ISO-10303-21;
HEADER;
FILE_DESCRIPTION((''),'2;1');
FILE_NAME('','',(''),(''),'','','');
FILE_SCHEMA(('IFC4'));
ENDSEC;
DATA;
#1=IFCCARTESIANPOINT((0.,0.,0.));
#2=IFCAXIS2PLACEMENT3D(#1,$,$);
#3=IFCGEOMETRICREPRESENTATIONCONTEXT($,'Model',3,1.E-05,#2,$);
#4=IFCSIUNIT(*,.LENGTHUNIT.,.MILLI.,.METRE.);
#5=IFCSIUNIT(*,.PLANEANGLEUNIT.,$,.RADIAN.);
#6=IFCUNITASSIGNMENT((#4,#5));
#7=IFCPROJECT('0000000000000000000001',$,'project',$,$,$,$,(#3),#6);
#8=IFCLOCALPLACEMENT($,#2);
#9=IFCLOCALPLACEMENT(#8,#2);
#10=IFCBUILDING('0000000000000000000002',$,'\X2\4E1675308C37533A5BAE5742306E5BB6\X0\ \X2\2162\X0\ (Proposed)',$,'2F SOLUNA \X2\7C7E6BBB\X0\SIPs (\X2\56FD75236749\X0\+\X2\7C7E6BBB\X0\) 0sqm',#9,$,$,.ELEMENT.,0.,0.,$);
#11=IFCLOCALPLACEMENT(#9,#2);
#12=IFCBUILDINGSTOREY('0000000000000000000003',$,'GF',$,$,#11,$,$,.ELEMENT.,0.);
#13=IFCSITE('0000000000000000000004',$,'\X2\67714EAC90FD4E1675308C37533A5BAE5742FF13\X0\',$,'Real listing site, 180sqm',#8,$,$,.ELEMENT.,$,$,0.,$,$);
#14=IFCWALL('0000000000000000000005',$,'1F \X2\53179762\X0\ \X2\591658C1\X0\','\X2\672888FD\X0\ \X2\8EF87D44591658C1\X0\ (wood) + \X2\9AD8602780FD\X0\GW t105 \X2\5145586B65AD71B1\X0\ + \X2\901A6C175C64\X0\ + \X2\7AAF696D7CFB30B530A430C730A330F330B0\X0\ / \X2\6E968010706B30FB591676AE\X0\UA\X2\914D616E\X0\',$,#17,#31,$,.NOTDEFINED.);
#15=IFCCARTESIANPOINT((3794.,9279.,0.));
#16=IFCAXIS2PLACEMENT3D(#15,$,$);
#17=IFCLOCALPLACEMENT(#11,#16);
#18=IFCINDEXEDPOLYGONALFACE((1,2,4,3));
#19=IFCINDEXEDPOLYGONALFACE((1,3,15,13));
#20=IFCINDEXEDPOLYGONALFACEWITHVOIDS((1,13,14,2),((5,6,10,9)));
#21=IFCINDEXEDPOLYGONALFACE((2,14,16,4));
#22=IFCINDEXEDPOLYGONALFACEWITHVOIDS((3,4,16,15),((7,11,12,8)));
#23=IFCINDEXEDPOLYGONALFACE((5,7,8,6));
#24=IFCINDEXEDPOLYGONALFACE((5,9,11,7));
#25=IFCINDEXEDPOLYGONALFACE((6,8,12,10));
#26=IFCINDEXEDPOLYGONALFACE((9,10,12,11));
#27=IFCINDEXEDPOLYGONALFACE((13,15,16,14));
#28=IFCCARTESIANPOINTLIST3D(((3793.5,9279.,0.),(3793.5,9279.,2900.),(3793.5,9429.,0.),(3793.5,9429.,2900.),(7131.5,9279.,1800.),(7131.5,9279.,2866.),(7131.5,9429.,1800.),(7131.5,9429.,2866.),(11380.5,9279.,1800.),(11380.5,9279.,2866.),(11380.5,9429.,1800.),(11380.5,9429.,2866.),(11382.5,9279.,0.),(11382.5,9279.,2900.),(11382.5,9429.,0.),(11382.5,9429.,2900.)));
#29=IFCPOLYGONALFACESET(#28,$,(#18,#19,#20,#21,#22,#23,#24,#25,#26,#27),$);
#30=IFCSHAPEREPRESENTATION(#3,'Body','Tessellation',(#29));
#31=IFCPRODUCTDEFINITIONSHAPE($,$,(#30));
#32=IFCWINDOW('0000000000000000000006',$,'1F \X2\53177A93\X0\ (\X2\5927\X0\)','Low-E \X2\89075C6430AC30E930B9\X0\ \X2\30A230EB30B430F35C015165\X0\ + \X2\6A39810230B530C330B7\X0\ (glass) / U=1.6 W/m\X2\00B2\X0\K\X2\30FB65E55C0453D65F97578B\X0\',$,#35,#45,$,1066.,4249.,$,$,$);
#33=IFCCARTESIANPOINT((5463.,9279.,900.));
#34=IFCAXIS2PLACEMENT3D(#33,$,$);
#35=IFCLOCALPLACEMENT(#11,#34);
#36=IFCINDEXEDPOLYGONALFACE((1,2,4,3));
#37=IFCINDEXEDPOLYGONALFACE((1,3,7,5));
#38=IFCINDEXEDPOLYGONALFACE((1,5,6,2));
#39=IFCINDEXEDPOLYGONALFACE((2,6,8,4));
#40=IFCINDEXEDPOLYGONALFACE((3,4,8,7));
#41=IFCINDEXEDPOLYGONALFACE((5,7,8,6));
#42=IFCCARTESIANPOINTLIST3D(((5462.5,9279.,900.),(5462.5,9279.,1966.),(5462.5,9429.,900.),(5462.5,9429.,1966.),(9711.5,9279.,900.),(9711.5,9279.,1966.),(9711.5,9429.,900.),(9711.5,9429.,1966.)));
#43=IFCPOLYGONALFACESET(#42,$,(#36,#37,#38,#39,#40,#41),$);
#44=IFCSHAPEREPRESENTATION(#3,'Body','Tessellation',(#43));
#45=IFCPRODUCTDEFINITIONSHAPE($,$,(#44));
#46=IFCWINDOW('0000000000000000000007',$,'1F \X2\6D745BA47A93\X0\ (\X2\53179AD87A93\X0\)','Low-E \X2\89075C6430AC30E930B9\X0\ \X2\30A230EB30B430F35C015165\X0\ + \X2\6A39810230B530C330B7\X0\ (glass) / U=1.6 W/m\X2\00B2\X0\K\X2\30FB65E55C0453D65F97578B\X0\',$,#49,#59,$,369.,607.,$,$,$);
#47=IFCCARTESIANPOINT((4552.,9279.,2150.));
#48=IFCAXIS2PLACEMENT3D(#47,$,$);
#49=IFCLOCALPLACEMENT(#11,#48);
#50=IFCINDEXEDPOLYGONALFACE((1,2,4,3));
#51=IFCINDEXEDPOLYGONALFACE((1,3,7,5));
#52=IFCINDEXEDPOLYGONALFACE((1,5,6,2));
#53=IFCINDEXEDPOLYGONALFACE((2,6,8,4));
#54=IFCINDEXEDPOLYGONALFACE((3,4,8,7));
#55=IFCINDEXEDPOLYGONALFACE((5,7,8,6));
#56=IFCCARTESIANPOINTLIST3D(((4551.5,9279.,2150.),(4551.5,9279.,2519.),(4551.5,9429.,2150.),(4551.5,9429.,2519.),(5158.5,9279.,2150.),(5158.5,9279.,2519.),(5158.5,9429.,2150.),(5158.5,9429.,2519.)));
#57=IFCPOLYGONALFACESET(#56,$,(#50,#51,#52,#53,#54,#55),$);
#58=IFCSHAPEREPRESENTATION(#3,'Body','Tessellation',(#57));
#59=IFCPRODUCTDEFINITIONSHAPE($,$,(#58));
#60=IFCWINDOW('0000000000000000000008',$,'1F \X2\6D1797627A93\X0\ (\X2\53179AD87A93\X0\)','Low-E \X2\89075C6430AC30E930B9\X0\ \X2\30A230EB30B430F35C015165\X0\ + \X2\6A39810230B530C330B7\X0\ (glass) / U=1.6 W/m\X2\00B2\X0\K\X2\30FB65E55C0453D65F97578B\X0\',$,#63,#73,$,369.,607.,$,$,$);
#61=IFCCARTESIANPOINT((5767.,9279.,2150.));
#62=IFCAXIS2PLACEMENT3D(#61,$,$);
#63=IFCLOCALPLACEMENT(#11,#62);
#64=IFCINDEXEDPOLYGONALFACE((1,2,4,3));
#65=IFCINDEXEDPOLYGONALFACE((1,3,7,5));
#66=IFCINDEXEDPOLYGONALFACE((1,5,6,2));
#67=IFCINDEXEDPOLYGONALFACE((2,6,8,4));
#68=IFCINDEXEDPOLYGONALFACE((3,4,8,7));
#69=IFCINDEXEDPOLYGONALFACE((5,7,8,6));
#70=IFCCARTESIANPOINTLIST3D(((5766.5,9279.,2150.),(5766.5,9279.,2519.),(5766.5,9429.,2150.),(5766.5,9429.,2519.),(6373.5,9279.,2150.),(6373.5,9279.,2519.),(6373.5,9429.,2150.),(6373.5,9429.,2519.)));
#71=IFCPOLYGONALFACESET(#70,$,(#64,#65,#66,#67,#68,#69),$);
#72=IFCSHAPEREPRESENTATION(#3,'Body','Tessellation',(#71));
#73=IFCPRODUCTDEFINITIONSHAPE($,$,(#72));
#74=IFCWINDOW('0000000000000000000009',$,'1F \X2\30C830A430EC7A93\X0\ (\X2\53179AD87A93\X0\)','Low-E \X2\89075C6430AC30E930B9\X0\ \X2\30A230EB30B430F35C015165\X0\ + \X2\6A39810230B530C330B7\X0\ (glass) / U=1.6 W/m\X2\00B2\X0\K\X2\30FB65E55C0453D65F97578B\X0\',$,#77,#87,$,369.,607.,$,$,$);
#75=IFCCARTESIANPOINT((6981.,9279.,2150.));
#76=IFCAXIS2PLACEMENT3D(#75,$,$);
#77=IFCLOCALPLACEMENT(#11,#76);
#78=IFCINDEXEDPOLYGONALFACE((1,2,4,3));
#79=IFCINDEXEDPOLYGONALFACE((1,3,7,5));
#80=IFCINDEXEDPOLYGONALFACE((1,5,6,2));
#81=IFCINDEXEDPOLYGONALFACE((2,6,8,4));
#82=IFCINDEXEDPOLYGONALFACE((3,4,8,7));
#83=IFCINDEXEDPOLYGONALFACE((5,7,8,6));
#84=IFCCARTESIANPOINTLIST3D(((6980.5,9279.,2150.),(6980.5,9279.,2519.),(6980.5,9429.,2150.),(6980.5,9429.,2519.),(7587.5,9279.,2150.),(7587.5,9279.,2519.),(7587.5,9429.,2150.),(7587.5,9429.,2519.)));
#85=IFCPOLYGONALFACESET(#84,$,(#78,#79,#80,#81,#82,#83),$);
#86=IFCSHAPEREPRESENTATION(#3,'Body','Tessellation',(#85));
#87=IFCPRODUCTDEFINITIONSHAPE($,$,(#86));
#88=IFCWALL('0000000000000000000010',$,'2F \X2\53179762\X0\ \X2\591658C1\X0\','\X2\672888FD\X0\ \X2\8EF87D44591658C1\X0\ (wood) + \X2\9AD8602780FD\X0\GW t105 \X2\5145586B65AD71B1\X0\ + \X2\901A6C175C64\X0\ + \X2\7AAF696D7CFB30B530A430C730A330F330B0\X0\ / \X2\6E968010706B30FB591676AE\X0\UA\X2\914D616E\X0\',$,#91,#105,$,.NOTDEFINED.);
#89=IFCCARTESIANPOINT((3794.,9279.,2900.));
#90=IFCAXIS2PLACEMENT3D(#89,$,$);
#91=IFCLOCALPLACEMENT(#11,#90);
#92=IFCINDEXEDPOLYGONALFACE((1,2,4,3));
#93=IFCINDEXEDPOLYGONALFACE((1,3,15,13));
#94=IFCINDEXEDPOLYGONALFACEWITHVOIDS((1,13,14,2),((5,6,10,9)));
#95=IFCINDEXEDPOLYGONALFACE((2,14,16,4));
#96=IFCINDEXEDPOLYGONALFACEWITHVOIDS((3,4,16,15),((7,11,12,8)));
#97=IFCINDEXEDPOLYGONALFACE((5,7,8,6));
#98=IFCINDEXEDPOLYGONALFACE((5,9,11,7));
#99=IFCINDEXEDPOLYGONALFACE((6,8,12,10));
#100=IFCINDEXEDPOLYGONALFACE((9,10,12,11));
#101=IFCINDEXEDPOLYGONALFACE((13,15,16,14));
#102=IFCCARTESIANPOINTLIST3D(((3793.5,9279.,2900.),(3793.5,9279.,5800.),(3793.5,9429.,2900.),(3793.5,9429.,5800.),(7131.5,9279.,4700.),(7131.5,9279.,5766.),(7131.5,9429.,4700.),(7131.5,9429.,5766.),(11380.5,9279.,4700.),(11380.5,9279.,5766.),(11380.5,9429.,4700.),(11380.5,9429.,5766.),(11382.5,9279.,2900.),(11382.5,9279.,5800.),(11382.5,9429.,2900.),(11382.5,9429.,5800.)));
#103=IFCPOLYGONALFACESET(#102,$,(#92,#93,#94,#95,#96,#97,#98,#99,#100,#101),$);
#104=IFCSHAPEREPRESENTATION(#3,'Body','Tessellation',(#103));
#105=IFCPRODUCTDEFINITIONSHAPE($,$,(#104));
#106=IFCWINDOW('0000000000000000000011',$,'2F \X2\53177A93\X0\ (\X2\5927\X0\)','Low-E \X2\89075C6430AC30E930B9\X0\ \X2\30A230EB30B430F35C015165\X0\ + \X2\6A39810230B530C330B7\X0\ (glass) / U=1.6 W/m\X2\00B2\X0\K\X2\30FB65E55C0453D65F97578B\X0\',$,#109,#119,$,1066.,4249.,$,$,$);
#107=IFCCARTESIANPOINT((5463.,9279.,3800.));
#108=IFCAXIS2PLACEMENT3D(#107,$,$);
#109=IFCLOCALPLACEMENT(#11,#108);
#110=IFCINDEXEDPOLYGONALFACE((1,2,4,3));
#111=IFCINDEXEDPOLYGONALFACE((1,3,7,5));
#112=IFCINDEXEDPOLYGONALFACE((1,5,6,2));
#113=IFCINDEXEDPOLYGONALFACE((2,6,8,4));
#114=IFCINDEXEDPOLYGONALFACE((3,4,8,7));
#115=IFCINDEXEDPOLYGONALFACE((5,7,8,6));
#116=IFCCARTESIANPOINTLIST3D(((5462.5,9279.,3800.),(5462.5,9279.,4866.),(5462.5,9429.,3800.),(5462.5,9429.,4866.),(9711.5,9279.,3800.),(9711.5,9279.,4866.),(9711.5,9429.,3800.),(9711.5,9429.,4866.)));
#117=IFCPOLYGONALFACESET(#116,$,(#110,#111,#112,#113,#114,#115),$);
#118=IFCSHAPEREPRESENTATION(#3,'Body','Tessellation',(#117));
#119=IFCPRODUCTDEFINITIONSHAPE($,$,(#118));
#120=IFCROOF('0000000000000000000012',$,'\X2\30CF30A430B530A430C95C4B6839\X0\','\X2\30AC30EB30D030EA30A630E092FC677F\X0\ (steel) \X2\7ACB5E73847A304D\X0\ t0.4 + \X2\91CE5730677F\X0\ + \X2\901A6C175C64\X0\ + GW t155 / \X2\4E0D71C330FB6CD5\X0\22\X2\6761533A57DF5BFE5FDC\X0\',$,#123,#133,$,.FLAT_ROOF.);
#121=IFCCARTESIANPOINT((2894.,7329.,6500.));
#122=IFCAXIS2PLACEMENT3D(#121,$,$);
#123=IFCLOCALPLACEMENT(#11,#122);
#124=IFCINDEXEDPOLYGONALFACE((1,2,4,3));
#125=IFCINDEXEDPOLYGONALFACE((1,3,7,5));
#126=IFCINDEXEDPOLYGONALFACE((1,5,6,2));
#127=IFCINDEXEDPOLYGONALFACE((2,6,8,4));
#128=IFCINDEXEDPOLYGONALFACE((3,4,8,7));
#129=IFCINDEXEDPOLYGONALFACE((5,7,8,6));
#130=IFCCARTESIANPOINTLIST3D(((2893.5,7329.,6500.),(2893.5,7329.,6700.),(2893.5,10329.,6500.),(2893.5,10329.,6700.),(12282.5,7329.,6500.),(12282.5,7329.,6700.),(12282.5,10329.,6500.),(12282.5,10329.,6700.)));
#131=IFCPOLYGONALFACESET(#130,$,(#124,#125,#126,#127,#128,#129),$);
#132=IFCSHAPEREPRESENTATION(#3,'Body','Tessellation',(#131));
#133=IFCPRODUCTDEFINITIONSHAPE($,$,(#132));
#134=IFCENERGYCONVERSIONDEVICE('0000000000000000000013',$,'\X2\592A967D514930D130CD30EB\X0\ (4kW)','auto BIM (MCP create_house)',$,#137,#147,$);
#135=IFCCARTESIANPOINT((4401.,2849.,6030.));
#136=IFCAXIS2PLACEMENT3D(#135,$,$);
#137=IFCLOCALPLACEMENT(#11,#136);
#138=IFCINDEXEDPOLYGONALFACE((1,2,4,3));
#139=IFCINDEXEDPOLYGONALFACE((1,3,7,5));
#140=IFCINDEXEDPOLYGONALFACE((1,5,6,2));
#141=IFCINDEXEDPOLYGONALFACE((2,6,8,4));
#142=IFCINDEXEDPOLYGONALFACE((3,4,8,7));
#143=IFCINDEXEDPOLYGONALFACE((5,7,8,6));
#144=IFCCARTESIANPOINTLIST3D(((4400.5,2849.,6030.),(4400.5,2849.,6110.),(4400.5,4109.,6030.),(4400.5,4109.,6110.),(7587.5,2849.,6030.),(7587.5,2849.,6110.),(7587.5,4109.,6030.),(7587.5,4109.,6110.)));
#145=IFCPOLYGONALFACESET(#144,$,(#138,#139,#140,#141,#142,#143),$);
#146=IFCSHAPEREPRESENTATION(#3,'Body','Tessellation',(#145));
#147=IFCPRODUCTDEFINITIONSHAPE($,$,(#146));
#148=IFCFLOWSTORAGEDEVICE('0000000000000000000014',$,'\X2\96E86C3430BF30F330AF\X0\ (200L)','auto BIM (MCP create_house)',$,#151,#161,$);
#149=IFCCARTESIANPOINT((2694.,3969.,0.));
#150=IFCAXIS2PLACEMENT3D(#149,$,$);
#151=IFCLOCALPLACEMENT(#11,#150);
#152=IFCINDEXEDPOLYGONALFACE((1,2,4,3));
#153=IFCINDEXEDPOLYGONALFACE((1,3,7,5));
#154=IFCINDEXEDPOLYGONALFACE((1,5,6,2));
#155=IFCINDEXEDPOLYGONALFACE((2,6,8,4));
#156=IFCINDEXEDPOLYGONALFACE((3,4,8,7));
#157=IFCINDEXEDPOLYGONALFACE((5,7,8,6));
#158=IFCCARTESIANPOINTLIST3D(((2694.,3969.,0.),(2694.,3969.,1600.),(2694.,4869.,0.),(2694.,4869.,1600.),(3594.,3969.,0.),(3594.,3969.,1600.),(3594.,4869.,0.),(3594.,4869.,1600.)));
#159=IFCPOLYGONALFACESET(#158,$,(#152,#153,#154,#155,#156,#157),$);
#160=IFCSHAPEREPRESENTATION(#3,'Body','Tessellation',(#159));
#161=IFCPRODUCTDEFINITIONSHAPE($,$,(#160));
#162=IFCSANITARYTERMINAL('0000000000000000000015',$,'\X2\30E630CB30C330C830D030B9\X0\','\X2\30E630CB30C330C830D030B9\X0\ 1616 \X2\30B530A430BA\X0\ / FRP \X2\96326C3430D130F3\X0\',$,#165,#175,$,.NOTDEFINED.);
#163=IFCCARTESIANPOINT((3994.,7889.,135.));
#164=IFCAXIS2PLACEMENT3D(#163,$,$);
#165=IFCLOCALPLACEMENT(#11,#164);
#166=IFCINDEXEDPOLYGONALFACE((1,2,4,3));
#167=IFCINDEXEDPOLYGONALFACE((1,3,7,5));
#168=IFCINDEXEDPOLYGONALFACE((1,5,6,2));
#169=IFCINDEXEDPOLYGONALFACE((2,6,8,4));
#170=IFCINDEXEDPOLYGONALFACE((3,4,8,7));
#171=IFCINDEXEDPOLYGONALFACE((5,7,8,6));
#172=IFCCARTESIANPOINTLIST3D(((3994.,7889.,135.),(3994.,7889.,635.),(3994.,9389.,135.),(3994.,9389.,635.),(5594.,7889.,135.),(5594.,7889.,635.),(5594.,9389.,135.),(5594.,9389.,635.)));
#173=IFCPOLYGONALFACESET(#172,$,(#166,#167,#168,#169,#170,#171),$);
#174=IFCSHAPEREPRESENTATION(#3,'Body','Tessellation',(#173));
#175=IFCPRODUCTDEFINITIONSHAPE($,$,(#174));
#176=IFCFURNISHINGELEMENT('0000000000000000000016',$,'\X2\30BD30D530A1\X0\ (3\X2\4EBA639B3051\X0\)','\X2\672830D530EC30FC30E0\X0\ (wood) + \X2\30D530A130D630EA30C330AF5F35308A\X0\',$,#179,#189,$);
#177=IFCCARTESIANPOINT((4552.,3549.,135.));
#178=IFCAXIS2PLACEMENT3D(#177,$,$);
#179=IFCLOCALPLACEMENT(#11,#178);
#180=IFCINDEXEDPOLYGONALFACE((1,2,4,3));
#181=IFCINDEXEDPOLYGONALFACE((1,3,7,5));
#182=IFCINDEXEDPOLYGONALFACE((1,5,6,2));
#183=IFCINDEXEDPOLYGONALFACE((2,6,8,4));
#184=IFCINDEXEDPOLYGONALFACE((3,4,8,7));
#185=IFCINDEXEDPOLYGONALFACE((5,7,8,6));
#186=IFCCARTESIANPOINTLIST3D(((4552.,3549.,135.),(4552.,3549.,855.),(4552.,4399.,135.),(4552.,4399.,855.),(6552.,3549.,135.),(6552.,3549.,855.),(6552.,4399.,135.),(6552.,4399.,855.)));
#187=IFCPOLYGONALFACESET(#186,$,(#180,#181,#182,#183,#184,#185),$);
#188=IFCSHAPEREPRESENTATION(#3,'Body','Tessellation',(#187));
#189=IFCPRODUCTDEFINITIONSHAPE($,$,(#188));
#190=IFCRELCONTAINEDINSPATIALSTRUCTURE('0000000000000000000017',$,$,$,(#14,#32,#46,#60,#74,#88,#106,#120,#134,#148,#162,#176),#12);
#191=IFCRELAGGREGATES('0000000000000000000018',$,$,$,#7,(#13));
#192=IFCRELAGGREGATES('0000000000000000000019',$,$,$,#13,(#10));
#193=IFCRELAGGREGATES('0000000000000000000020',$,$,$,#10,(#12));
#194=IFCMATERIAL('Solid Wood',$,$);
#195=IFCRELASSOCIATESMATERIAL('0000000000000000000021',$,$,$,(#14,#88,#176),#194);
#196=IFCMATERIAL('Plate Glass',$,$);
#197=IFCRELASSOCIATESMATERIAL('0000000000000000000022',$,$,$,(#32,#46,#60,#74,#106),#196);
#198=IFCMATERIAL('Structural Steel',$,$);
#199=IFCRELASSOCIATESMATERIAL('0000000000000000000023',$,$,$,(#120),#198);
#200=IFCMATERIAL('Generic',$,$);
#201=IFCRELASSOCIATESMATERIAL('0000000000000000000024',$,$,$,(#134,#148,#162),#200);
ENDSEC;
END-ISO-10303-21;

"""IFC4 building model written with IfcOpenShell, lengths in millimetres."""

from ifc_helpers import new_model, si_unit, frame, frame_2d, origin, place, context, project, spatial, rectangle, extrude, material, element, fill, save


model = new_model("IFC4")

# Units and contexts
model_context = context("Model", 3, precision=1e-05, world=origin())
ifc_project = project(units=[si_unit("LENGTHUNIT", "METRE", prefix="MILLI"), si_unit("PLANEANGLEUNIT", "RADIAN")], contexts=[model_context])

# Site, building, storey
site_placement = place(None, origin())
site = spatial("IfcSite", under=ifc_project, at=site_placement, Name="東京都世田谷区宮坂３", ObjectType="Real listing site, 180sqm", CompositionType="ELEMENT", RefElevation=0.0)
building_placement = place(site_placement, origin())
building = spatial("IfcBuilding", under=site, at=building_placement, Name="世田谷区宮坂の家 Ⅲ (Proposed)", ObjectType="2F SOLUNA 籾殻SIPs (国産杉+籾殻) 0sqm", CompositionType="ELEMENT", ElevationOfRefHeight=0.0, ElevationOfTerrain=0.0)
storey_placement = place(building_placement, origin())
storey = spatial("IfcBuildingStorey", under=building, at=storey_placement, Name="GF", CompositionType="ELEMENT", Elevation=0.0)

# Wall, openings, windows
ifc_material_1 = material(Name="Solid Wood")
wall_1_placement = place(storey_placement, frame((3794.0, 9279.0, 0.0)))
wall_1 = element("IfcWall", 1, at=wall_1_placement, inside=storey, material=ifc_material_1, Name="1F 北面 外壁", Description="木製 軸組外壁 (wood) + 高性能GW t105 充填断熱 + 通気層 + 窯業系サイディング / 準耐火・外皮UA配慮", PredefinedType="NOTDEFINED", context=model_context, shape_type="SweptSolid", body=[
    extrude(rectangle(XDim=7589.0, YDim=150.0, at=frame_2d((3794.0, 75.0))), frame((3794.0, 9279.0, 0.0)), (0.0, 0.0, 1.0), 2900.0),
])
opening_1_placement = place(storey_placement, frame((5463.0, 9279.0, 900.0)))
opening_1 = element("IfcOpeningElement", 2, at=opening_1_placement, cuts=wall_1, PredefinedType="NOTDEFINED", context=model_context, shape_type="SweptSolid", body=[
    extrude(rectangle(XDim=4249.0, YDim=150.0, at=frame_2d((2124.0, 75.0))), frame((5463.0, 9279.0, 900.0)), (0.0, 0.0, 1.0), 1066.0),
])
opening_2_placement = place(storey_placement, frame((4552.0, 9279.0, 2150.0)))
opening_2 = element("IfcOpeningElement", 3, at=opening_2_placement, cuts=wall_1, PredefinedType="NOTDEFINED", context=model_context, shape_type="SweptSolid", body=[
    extrude(rectangle(XDim=607.0, YDim=150.0, at=frame_2d((303.0, 75.0))), frame((4552.0, 9279.0, 2150.0)), (0.0, 0.0, 1.0), 369.0),
])
opening_3_placement = place(storey_placement, frame((5767.0, 9279.0, 2150.0)))
opening_3 = element("IfcOpeningElement", 4, at=opening_3_placement, cuts=wall_1, PredefinedType="NOTDEFINED", context=model_context, shape_type="SweptSolid", body=[
    extrude(rectangle(XDim=607.0, YDim=150.0, at=frame_2d((303.0, 75.0))), frame((5767.0, 9279.0, 2150.0)), (0.0, 0.0, 1.0), 369.0),
])
opening_4_placement = place(storey_placement, frame((6981.0, 9279.0, 2150.0)))
opening_4 = element("IfcOpeningElement", 5, at=opening_4_placement, cuts=wall_1, PredefinedType="NOTDEFINED", context=model_context, shape_type="SweptSolid", body=[
    extrude(rectangle(XDim=607.0, YDim=150.0, at=frame_2d((303.0, 75.0))), frame((6981.0, 9279.0, 2150.0)), (0.0, 0.0, 1.0), 369.0),
])
ifc_material_2 = material(Name="Plate Glass")
window_1_placement = place(storey_placement, frame((5463.0, 9279.0, 900.0)))
window_1 = element("IfcWindow", 6, at=window_1_placement, inside=storey, material=ifc_material_2, Name="1F 北窓 (大)", Description="Low-E 複層ガラス アルゴン封入 + 樹脂サッシ (glass) / U=1.6 W/m²K・日射取得型", OverallHeight=1066.0, OverallWidth=4249.0, context=model_context, shape_type="SweptSolid", body=[
    extrude(rectangle(XDim=4249.0, YDim=150.0, at=frame_2d((2124.0, 75.0))), frame((5463.0, 9279.0, 900.0)), (0.0, 0.0, 1.0), 1066.0),
])
fill(opening_1, window_1)
window_2_placement = place(storey_placement, frame((4552.0, 9279.0, 2150.0)))
window_2 = element("IfcWindow", 7, at=window_2_placement, inside=storey, material=ifc_material_2, Name="1F 浴室窓 (北高窓)", Description="Low-E 複層ガラス アルゴン封入 + 樹脂サッシ (glass) / U=1.6 W/m²K・日射取得型", OverallHeight=369.0, OverallWidth=607.0, context=model_context, shape_type="SweptSolid", body=[
    extrude(rectangle(XDim=607.0, YDim=150.0, at=frame_2d((303.0, 75.0))), frame((4552.0, 9279.0, 2150.0)), (0.0, 0.0, 1.0), 369.0),
])
fill(opening_2, window_2)
window_3_placement = place(storey_placement, frame((5767.0, 9279.0, 2150.0)))
window_3 = element("IfcWindow", 8, at=window_3_placement, inside=storey, material=ifc_material_2, Name="1F 洗面窓 (北高窓)", Description="Low-E 複層ガラス アルゴン封入 + 樹脂サッシ (glass) / U=1.6 W/m²K・日射取得型", OverallHeight=369.0, OverallWidth=607.0, context=model_context, shape_type="SweptSolid", body=[
    extrude(rectangle(XDim=607.0, YDim=150.0, at=frame_2d((303.0, 75.0))), frame((5767.0, 9279.0, 2150.0)), (0.0, 0.0, 1.0), 369.0),
])
fill(opening_3, window_3)
window_4_placement = place(storey_placement, frame((6981.0, 9279.0, 2150.0)))
window_4 = element("IfcWindow", 9, at=window_4_placement, inside=storey, material=ifc_material_2, Name="1F トイレ窓 (北高窓)", Description="Low-E 複層ガラス アルゴン封入 + 樹脂サッシ (glass) / U=1.6 W/m²K・日射取得型", OverallHeight=369.0, OverallWidth=607.0, context=model_context, shape_type="SweptSolid", body=[
    extrude(rectangle(XDim=607.0, YDim=150.0, at=frame_2d((303.0, 75.0))), frame((6981.0, 9279.0, 2150.0)), (0.0, 0.0, 1.0), 369.0),
])
fill(opening_4, window_4)

# Wall, opening, window
wall_2_placement = place(storey_placement, frame((3794.0, 9279.0, 2900.0)))
wall_2 = element("IfcWall", 10, at=wall_2_placement, inside=storey, material=ifc_material_1, Name="2F 北面 外壁", Description="木製 軸組外壁 (wood) + 高性能GW t105 充填断熱 + 通気層 + 窯業系サイディング / 準耐火・外皮UA配慮", PredefinedType="NOTDEFINED", context=model_context, shape_type="SweptSolid", body=[
    extrude(rectangle(XDim=7589.0, YDim=150.0, at=frame_2d((3794.0, 75.0))), frame((3794.0, 9279.0, 2900.0)), (0.0, 0.0, 1.0), 2900.0),
])
opening_5_placement = place(storey_placement, frame((5463.0, 9279.0, 3800.0)))
opening_5 = element("IfcOpeningElement", 11, at=opening_5_placement, cuts=wall_2, PredefinedType="NOTDEFINED", context=model_context, shape_type="SweptSolid", body=[
    extrude(rectangle(XDim=4249.0, YDim=150.0, at=frame_2d((2124.0, 75.0))), frame((5463.0, 9279.0, 3800.0)), (0.0, 0.0, 1.0), 1066.0),
])
window_5_placement = place(storey_placement, frame((5463.0, 9279.0, 3800.0)))
window_5 = element("IfcWindow", 12, at=window_5_placement, inside=storey, material=ifc_material_2, Name="2F 北窓 (大)", Description="Low-E 複層ガラス アルゴン封入 + 樹脂サッシ (glass) / U=1.6 W/m²K・日射取得型", OverallHeight=1066.0, OverallWidth=4249.0, context=model_context, shape_type="SweptSolid", body=[
    extrude(rectangle(XDim=4249.0, YDim=150.0, at=frame_2d((2124.0, 75.0))), frame((5463.0, 9279.0, 3800.0)), (0.0, 0.0, 1.0), 1066.0),
])
fill(opening_5, window_5)

# Roof
ifc_material_3 = material(Name="Structural Steel")
roof_placement = place(storey_placement, frame((2894.0, 7329.0, 6500.0)))
element("IfcRoof", 13, at=roof_placement, inside=storey, material=ifc_material_3, Name="ハイサイド屋根", Description="ガルバリウム鋼板 (steel) 立平葺き t0.4 + 野地板 + 通気層 + GW t155 / 不燃・法22条区域対応", PredefinedType="FLAT_ROOF", context=model_context, shape_type="SweptSolid", body=[
    extrude(rectangle(XDim=9389.0, YDim=3000.0, at=frame_2d((4694.0, 1500.0))), frame((2894.0, 7329.0, 6500.0)), (0.0, 0.0, 1.0), 200.0),
])

# Energy conversion device
ifc_material_4 = material(Name="Generic")
energy_conversion_device_placement = place(storey_placement, frame((4401.0, 2849.0, 6030.0)))
element("IfcEnergyConversionDevice", 14, at=energy_conversion_device_placement, inside=storey, material=ifc_material_4, Name="太陽光パネル (4kW)", Description="auto BIM (MCP create_house)", context=model_context, shape_type="SweptSolid", body=[
    extrude(rectangle(XDim=3187.0, YDim=1260.0, at=frame_2d((1593.0, 630.0))), frame((4401.0, 2849.0, 6030.0)), (0.0, 0.0, 1.0), 80.0),
])

# Flow storage device
flow_storage_device_placement = place(storey_placement, frame((2694.0, 3969.0, 0.0)))
element("IfcFlowStorageDevice", 15, at=flow_storage_device_placement, inside=storey, material=ifc_material_4, Name="雨水タンク (200L)", Description="auto BIM (MCP create_house)", context=model_context, shape_type="SweptSolid", body=[
    extrude(rectangle(XDim=900.0, YDim=900.0, at=frame_2d((450.0, 450.0))), frame((2694.0, 3969.0, 0.0)), (0.0, 0.0, 1.0), 1600.0),
])

# Sanitary terminal
sanitary_terminal_placement = place(storey_placement, frame((3994.0, 7889.0, 135.0)))
element("IfcSanitaryTerminal", 16, at=sanitary_terminal_placement, inside=storey, material=ifc_material_4, Name="ユニットバス", Description="ユニットバス 1616 サイズ / FRP 防水パン", PredefinedType="NOTDEFINED", context=model_context, shape_type="SweptSolid", body=[
    extrude(rectangle(XDim=1600.0, YDim=1500.0, at=frame_2d((800.0, 750.0))), frame((3994.0, 7889.0, 135.0)), (0.0, 0.0, 1.0), 500.0),
])

# Furnishing element
furnishing_1_placement = place(storey_placement, frame((4552.0, 3549.0, 135.0)))
element("IfcFurnishingElement", 17, at=furnishing_1_placement, inside=storey, material=ifc_material_1, Name="ソファ (3人掛け)", Description="木フレーム (wood) + ファブリック張り", context=model_context, shape_type="SweptSolid", body=[
    extrude(rectangle(XDim=2000.0, YDim=850.0, at=frame_2d((1000.0, 425.0))), frame((4552.0, 3549.0, 135.0)), (0.0, 0.0, 1.0), 720.0),
])

save(model, "model.ifc")
